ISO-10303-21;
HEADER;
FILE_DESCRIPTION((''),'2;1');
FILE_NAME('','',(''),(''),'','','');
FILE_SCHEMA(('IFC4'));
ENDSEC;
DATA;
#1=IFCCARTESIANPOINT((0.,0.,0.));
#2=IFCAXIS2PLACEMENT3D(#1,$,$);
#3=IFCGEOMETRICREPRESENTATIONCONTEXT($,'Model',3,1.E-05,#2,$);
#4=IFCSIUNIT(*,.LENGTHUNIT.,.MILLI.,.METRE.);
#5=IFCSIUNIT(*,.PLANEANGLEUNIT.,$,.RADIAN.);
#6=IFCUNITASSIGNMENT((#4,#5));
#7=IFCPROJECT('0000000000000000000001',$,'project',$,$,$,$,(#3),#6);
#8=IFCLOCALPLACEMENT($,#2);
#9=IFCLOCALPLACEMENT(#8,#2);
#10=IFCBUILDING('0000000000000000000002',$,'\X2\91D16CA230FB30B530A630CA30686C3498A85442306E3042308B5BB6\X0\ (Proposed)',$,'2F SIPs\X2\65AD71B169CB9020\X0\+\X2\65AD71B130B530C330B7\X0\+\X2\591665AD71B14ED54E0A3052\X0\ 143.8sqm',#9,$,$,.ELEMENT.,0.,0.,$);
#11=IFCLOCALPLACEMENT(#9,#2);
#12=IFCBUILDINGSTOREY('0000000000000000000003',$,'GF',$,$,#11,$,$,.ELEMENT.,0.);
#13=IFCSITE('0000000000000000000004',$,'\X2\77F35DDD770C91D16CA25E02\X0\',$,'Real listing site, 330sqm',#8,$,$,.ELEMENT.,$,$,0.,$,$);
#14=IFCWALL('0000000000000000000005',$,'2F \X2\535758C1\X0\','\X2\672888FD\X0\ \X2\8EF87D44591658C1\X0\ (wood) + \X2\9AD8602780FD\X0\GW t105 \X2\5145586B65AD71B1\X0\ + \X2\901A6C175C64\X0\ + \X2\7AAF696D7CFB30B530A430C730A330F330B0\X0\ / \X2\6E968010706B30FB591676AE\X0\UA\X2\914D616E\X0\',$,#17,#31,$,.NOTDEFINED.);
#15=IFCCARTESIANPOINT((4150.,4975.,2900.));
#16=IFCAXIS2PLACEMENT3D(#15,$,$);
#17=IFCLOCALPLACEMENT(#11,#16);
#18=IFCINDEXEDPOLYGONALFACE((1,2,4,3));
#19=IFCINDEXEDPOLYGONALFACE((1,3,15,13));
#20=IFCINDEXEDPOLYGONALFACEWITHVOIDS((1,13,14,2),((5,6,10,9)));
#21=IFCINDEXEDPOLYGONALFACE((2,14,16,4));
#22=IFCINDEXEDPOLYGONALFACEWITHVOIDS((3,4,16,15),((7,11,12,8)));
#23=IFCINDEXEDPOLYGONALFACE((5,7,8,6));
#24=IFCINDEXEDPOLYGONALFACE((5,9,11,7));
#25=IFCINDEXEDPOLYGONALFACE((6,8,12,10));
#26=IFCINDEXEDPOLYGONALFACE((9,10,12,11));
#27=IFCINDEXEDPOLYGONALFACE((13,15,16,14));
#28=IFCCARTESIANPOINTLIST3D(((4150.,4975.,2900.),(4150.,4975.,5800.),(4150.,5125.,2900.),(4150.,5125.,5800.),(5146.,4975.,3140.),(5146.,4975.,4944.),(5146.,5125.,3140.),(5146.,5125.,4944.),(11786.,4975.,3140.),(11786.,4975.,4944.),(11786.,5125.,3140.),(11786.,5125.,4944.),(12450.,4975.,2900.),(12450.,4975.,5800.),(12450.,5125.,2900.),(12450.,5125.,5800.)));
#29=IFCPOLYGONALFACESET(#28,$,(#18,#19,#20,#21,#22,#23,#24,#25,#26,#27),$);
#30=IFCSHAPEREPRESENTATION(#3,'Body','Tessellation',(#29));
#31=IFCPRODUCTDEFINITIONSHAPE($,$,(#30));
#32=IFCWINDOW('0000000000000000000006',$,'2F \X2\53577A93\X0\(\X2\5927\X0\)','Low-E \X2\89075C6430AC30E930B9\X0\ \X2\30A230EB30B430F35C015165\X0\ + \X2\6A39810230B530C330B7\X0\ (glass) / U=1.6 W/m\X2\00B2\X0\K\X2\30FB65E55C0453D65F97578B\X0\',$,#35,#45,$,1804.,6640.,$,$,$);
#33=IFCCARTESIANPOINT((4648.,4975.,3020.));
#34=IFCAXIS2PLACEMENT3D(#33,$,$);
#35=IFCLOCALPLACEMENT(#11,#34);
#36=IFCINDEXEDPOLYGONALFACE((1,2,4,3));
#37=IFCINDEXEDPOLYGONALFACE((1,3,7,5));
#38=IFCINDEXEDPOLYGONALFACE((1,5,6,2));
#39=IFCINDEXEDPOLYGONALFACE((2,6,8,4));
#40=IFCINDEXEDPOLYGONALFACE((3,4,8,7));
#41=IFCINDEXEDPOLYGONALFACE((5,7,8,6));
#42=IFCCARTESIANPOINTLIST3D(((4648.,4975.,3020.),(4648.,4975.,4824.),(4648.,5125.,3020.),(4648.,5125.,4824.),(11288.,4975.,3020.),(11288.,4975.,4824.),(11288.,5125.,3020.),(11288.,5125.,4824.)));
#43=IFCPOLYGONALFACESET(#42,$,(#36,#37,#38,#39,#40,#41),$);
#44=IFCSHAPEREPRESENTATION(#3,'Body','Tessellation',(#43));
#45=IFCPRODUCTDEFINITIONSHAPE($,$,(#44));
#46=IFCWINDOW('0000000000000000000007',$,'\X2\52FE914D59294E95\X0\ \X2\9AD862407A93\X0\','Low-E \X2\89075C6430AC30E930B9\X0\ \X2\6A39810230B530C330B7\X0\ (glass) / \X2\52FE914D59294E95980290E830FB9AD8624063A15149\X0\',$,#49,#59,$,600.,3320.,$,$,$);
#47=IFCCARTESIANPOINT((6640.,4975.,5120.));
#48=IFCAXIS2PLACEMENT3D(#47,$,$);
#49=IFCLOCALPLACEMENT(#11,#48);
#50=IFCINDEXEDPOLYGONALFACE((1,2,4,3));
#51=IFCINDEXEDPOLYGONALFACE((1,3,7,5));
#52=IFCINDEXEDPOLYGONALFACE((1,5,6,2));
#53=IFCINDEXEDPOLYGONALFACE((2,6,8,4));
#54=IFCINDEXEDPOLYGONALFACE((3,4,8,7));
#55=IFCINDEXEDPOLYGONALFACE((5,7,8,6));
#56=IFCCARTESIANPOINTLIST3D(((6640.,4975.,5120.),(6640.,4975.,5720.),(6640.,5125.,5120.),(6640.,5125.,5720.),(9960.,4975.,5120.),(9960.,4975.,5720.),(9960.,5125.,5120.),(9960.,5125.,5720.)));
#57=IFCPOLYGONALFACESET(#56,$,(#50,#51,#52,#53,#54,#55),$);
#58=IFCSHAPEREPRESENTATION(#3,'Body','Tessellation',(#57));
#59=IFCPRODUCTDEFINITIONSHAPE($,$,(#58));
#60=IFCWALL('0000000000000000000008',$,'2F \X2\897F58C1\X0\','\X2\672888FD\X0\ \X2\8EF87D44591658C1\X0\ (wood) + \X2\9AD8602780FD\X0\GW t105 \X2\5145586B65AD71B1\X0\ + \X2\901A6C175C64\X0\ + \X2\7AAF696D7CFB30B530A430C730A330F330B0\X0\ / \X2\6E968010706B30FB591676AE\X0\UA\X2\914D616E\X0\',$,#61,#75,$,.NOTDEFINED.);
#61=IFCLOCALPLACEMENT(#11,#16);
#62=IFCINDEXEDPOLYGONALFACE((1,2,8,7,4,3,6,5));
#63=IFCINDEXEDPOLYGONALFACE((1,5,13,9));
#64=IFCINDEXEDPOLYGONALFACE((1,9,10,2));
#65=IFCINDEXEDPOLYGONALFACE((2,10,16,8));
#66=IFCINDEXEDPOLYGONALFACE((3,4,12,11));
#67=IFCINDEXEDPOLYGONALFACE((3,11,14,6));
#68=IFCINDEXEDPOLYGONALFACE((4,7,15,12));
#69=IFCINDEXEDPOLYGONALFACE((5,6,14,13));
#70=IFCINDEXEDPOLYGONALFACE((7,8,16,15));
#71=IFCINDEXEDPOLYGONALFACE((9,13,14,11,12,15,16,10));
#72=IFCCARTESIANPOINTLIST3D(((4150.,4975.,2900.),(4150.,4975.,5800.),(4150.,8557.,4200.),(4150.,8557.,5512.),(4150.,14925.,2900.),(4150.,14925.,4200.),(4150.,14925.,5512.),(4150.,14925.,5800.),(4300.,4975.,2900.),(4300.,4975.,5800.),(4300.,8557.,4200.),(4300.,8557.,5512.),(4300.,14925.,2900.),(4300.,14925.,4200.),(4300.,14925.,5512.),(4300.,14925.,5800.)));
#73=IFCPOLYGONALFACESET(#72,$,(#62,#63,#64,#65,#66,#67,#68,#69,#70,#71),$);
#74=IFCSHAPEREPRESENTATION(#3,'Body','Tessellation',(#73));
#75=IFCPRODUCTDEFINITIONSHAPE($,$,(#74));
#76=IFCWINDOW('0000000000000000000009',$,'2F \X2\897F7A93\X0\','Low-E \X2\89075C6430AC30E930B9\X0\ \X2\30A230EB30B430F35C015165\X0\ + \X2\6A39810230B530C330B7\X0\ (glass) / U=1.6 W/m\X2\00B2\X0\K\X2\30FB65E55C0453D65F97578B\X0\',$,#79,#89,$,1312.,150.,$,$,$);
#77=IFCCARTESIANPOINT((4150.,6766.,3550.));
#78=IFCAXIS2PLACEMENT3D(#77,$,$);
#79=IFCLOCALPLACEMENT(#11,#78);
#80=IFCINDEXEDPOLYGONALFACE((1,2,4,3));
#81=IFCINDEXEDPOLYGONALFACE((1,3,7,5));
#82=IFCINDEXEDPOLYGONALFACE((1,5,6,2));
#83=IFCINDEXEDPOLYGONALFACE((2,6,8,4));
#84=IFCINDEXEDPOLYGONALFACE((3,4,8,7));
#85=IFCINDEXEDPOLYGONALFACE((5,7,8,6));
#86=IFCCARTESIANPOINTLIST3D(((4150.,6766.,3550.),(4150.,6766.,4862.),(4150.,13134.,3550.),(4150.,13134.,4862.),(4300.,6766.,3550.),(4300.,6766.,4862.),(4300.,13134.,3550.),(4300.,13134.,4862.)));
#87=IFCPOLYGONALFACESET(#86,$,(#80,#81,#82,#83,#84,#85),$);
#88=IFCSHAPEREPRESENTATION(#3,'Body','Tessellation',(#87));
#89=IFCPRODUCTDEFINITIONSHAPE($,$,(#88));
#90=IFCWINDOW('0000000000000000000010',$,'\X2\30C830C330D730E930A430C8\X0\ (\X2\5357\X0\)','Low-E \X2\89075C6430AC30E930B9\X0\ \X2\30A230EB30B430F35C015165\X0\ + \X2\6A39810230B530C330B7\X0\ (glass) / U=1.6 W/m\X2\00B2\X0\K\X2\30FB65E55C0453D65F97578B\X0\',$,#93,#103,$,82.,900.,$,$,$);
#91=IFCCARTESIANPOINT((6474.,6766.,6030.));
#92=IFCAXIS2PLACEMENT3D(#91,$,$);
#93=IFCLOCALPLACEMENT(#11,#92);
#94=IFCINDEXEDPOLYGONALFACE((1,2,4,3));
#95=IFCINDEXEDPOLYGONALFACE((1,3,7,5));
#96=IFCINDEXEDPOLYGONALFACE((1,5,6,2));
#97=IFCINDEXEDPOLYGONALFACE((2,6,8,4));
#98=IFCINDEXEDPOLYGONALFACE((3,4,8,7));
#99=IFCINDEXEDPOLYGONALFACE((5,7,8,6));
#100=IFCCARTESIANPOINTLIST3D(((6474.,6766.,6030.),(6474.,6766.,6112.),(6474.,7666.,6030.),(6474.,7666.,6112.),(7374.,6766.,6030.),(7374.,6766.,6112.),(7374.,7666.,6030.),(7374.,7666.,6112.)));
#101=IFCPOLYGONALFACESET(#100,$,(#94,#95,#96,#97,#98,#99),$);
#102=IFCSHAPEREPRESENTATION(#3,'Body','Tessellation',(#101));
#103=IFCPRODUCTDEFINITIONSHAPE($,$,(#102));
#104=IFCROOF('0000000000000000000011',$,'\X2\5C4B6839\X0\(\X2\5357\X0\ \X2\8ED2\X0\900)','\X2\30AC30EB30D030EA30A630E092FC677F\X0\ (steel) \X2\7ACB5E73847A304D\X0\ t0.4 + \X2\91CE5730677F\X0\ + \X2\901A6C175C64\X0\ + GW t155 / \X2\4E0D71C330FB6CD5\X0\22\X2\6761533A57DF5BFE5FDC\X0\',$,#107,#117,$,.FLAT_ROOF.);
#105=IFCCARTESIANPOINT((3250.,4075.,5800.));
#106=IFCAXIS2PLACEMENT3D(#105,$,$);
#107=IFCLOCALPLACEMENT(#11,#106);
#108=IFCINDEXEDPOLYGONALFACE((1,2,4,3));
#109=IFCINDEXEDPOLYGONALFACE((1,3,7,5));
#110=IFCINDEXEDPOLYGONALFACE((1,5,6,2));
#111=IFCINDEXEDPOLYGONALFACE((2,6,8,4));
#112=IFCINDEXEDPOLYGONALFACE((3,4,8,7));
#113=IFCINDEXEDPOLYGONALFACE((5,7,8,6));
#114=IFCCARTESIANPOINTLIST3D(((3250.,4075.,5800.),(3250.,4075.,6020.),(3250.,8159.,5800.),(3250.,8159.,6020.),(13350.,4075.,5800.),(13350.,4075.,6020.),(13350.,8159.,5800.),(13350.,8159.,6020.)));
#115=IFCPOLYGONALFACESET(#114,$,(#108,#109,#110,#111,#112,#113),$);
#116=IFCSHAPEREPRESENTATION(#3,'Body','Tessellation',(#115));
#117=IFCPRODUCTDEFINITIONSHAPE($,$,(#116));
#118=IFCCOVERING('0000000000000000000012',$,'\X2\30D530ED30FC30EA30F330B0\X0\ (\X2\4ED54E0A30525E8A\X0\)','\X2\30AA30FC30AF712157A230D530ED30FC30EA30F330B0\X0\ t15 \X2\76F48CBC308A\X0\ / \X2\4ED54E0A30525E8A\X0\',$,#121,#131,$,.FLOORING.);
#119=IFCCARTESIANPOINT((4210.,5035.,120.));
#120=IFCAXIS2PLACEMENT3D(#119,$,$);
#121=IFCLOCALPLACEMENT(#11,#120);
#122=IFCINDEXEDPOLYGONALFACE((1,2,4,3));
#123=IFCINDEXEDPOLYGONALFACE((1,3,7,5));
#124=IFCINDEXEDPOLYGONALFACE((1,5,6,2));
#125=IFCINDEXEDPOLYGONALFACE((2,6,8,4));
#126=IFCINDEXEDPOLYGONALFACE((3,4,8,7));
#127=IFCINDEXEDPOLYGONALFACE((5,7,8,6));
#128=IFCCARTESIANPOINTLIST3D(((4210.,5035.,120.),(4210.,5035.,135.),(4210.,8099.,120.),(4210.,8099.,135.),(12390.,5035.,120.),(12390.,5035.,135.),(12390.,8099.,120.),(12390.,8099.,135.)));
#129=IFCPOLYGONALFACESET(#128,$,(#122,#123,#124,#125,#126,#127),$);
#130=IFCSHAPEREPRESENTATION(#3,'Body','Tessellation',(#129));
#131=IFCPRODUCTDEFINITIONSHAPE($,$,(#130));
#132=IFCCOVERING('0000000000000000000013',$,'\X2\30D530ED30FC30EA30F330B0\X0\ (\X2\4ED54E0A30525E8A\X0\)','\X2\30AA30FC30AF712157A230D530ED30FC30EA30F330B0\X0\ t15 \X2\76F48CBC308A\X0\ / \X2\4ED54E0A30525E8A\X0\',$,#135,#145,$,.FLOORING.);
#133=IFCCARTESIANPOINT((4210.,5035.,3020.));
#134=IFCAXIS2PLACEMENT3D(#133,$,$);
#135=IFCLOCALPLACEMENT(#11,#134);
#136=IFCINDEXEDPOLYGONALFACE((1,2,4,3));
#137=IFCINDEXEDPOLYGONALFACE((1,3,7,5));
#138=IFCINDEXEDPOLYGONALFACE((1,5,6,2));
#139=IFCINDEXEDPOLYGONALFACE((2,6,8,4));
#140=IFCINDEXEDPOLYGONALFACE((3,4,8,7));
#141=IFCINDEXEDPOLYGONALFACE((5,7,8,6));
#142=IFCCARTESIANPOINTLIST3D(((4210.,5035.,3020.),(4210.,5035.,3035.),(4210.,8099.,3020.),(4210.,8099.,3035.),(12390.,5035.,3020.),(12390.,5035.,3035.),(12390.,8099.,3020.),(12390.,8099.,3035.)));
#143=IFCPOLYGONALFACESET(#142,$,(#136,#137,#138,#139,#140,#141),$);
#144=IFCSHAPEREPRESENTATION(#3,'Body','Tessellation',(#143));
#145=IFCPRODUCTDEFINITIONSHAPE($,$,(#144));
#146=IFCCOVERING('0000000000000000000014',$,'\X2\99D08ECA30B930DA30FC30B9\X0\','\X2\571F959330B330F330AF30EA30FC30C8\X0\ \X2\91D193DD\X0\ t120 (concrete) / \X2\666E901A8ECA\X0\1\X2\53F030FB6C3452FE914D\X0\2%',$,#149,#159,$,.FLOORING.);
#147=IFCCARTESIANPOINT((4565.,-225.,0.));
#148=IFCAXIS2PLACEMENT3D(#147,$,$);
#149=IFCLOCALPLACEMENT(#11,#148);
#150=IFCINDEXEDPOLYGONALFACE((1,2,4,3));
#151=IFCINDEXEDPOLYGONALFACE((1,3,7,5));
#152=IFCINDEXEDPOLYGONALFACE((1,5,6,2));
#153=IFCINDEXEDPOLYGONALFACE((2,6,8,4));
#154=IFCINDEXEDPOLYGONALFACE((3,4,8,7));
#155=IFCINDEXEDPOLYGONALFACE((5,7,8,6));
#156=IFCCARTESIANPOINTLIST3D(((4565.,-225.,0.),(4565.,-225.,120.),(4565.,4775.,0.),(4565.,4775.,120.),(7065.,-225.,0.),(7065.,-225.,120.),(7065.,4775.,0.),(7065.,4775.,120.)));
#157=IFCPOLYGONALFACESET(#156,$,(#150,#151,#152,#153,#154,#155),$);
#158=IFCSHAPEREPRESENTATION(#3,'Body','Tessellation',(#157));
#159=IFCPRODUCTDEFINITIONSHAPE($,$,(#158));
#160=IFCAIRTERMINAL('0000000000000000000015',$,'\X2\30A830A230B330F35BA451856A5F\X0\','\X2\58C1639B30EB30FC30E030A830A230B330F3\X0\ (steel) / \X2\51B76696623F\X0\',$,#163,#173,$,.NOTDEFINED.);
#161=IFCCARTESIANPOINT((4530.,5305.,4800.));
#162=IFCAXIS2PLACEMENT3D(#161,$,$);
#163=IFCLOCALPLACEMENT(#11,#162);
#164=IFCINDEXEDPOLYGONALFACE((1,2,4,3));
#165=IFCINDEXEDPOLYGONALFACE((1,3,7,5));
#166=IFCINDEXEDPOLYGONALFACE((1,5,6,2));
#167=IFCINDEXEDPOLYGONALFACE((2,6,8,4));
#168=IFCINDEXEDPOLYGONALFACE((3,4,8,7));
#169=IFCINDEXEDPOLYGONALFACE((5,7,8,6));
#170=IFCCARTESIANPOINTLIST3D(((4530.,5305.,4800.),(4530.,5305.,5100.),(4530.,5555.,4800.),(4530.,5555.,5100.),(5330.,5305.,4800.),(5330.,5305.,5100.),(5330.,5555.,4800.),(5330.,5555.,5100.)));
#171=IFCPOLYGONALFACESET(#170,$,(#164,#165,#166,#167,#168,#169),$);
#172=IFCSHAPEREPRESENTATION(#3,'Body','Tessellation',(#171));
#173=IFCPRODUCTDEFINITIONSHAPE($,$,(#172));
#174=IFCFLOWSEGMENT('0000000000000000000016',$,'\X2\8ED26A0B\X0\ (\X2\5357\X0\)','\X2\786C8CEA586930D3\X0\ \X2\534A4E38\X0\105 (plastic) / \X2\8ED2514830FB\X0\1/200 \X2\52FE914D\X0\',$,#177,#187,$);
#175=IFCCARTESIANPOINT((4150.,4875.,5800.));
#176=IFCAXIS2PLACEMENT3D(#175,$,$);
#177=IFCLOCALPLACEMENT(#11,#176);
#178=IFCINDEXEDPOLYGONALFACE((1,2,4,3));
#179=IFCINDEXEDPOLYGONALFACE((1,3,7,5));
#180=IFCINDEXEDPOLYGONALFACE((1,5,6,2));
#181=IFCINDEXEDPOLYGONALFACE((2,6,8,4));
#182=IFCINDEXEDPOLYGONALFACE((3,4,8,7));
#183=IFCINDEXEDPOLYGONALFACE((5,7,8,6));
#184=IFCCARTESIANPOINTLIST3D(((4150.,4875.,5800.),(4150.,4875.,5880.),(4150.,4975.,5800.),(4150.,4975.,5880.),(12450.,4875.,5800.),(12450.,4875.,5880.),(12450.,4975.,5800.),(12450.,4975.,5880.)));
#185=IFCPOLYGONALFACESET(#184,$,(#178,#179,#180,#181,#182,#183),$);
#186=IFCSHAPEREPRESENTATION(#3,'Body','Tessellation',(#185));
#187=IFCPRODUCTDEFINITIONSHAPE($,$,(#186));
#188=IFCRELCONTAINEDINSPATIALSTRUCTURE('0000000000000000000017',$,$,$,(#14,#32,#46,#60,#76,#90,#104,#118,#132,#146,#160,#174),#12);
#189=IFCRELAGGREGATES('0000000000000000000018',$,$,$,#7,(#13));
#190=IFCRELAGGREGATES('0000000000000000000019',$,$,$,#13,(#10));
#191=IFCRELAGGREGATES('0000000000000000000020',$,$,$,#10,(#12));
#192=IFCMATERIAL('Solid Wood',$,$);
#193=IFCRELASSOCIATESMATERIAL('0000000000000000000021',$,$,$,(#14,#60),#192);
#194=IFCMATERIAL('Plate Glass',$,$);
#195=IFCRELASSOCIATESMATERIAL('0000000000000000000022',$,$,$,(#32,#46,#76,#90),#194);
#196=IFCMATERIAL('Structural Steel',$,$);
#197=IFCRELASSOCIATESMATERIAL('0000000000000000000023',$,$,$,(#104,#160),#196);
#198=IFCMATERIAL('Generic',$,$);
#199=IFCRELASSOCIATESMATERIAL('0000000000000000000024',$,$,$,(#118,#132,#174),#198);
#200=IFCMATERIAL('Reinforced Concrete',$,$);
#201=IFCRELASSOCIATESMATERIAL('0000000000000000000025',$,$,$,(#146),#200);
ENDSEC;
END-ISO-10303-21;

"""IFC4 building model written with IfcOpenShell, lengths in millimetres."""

from ifc_helpers import new_model, si_unit, frame, frame_2d, origin, place, context, project, spatial, rectangle, extrude, material, element, fill, save


model = new_model("IFC4")

# Units and contexts
model_context = context("Model", 3, precision=1e-05, world=origin())
ifc_project = project(units=[si_unit("LENGTHUNIT", "METRE", prefix="MILLI"), si_unit("PLANEANGLEUNIT", "RADIAN")], contexts=[model_context])

# Site, building, storey
site_placement = place(None, origin())
site = spatial("IfcSite", under=ifc_project, at=site_placement, Name="石川県金沢市", ObjectType="Real listing site, 330sqm", CompositionType="ELEMENT", RefElevation=0.0)
building_placement = place(site_placement, origin())
building = spatial("IfcBuilding", under=site, at=building_placement, Name="金沢・サウナと水風呂のある家 (Proposed)", ObjectType="2F SIPs断熱構造+断熱サッシ+外断熱仕上げ 143.8sqm", CompositionType="ELEMENT", ElevationOfRefHeight=0.0, ElevationOfTerrain=0.0)
storey_placement = place(building_placement, origin())
storey = spatial("IfcBuildingStorey", under=building, at=storey_placement, Name="GF", CompositionType="ELEMENT", Elevation=0.0)

# Shared definitions
ifc_material_1 = material(Name="Solid Wood")

# Shared definitions
ifc_material_2 = material(Name="Reinforced Concrete")

# Shared definitions
ifc_material_3 = material(Name="Plate Glass")

# Wall, openings, windows
wall_1_placement = place(storey_placement, frame((4150.0, 4975.0, 2900.0)))
wall_1 = element("IfcWall", 1, at=wall_1_placement, inside=storey, material=ifc_material_1, Name="2F 南壁", Description="木製 軸組外壁 (wood) + 高性能GW t105 充填断熱 + 通気層 + 窯業系サイディング / 準耐火・外皮UA配慮", PredefinedType="NOTDEFINED", context=model_context, shape_type="SweptSolid", body=[
    extrude(rectangle(XDim=8300.0, YDim=150.0, at=frame_2d((4150.0, 75.0))), frame((4150.0, 4975.0, 2900.0)), (0.0, 0.0, 1.0), 2900.0),
])
opening_1_placement = place(storey_placement, frame((4648.0, 4975.0, 3020.0)))
opening_1 = element("IfcOpeningElement", 2, at=opening_1_placement, cuts=wall_1, PredefinedType="NOTDEFINED", context=model_context, shape_type="SweptSolid", body=[
    extrude(rectangle(XDim=6640.0, YDim=150.0, at=frame_2d((3320.0, 75.0))), frame((4648.0, 4975.0, 3020.0)), (0.0, 0.0, 1.0), 1804.0),
])
opening_2_placement = place(storey_placement, frame((6640.0, 4975.0, 5120.0)))
opening_2 = element("IfcOpeningElement", 3, at=opening_2_placement, cuts=wall_1, PredefinedType="NOTDEFINED", context=model_context, shape_type="SweptSolid", body=[
    extrude(rectangle(XDim=3320.0, YDim=150.0, at=frame_2d((1660.0, 75.0))), frame((6640.0, 4975.0, 5120.0)), (0.0, 0.0, 1.0), 600.0),
])
window_1_placement = place(storey_placement, frame((4648.0, 4975.0, 3020.0)))
window_1 = element("IfcWindow", 4, at=window_1_placement, inside=storey, material=ifc_material_3, Name="2F 南窓(大)", Description="Low-E 複層ガラス アルゴン封入 + 樹脂サッシ (glass) / U=1.6 W/m²K・日射取得型", OverallHeight=1804.0, OverallWidth=6640.0, context=model_context, shape_type="SweptSolid", body=[
    extrude(rectangle(XDim=6640.0, YDim=150.0, at=frame_2d((3320.0, 75.0))), frame((4648.0, 4975.0, 3020.0)), (0.0, 0.0, 1.0), 1804.0),
])
fill(opening_1, window_1)
window_2_placement = place(storey_placement, frame((6640.0, 4975.0, 5120.0)))
window_2 = element("IfcWindow", 5, at=window_2_placement, inside=storey, material=ifc_material_3, Name="勾配天井 高所窓", Description="Low-E 複層ガラス 樹脂サッシ (glass) / 勾配天井頂部・高所採光", OverallHeight=600.0, OverallWidth=3320.0, context=model_context, shape_type="SweptSolid", body=[
    extrude(rectangle(XDim=3320.0, YDim=150.0, at=frame_2d((1660.0, 75.0))), frame((6640.0, 4975.0, 5120.0)), (0.0, 0.0, 1.0), 600.0),
])
fill(opening_2, window_2)

# Wall, opening, window
wall_2_placement = place(storey_placement, frame((4150.0, 4975.0, 2900.0)))
wall_2 = element("IfcWall", 6, at=wall_2_placement, inside=storey, material=ifc_material_1, Name="2F 西壁", Description="木製 軸組外壁 (wood) + 高性能GW t105 充填断熱 + 通気層 + 窯業系サイディング / 準耐火・外皮UA配慮", PredefinedType="NOTDEFINED", context=model_context, shape_type="SweptSolid", body=[
    extrude(rectangle(XDim=150.0, YDim=9950.0, at=frame_2d((75.0, 4975.0))), frame((4150.0, 4975.0, 2900.0)), (0.0, 0.0, 1.0), 2900.0),
])
opening_3_placement = place(storey_placement, frame((4150.0, 6766.0, 3550.0)))
opening_3 = element("IfcOpeningElement", 7, at=opening_3_placement, cuts=wall_2, PredefinedType="NOTDEFINED", context=model_context, shape_type="SweptSolid", body=[
    extrude(rectangle(XDim=150.0, YDim=6368.0, at=frame_2d((75.0, 3184.0))), frame((4150.0, 6766.0, 3550.0)), (0.0, 0.0, 1.0), 1312.0),
])
window_3_placement = place(storey_placement, frame((4150.0, 6766.0, 3550.0)))
window_3 = element("IfcWindow", 8, at=window_3_placement, inside=storey, material=ifc_material_3, Name="2F 西窓", Description="Low-E 複層ガラス アルゴン封入 + 樹脂サッシ (glass) / U=1.6 W/m²K・日射取得型", OverallHeight=1312.0, OverallWidth=150.0, context=model_context, shape_type="SweptSolid", body=[
    extrude(rectangle(XDim=150.0, YDim=6368.0, at=frame_2d((75.0, 3184.0))), frame((4150.0, 6766.0, 3550.0)), (0.0, 0.0, 1.0), 1312.0),
])
fill(opening_3, window_3)

# Window
window_4_placement = place(storey_placement, frame((6474.0, 6766.0, 6030.0)))
element("IfcWindow", 9, at=window_4_placement, inside=storey, material=ifc_material_3, Name="トップライト (南)", Description="Low-E 複層ガラス アルゴン封入 + 樹脂サッシ (glass) / U=1.6 W/m²K・日射取得型", OverallHeight=82.0, OverallWidth=900.0, context=model_context, shape_type="SweptSolid", body=[
    extrude(rectangle(XDim=900.0, YDim=900.0, at=frame_2d((450.0, 450.0))), frame((6474.0, 6766.0, 6030.0)), (0.0, 0.0, 1.0), 82.0),
])

# Roof
ifc_material_4 = material(Name="Structural Steel")
for number, where, name in (
    (10, (3250.0, 4075.0, 5800.0), "屋根(南 軒900)"),
):
    element("IfcRoof", number, at=place(storey_placement, frame(where)), inside=storey, material=ifc_material_4, Name=name, Description="ガルバリウム鋼板 (steel) 立平葺き t0.4 + 野地板 + 通気層 + GW t155 / 不燃・法22条区域対応", PredefinedType="FLAT_ROOF", context=model_context, shape_type="SweptSolid", body=[
        extrude(rectangle(XDim=10100.0, YDim=4084.0, at=frame_2d((5050.0, 2042.0))), frame((3250.0, 4075.0, 5800.0)), (0.0, 0.0, 1.0), 220.0),
    ])

# Coverings
ifc_material_5 = material(Name="Generic")
covering_1_placement = place(storey_placement, frame((4210.0, 5035.0, 120.0)))
element("IfcCovering", 11, at=covering_1_placement, inside=storey, material=ifc_material_5, Name="フローリング (仕上げ床)", Description="オーク無垢フローリング t15 直貼り / 仕上げ床", PredefinedType="FLOORING", context=model_context, shape_type="SweptSolid", body=[
    extrude(rectangle(XDim=8180.0, YDim=3064.0, at=frame_2d((4090.0, 1532.0))), frame((4210.0, 5035.0, 120.0)), (0.0, 0.0, 1.0), 15.0),
])
covering_2_placement = place(storey_placement, frame((4210.0, 5035.0, 3020.0)))
element("IfcCovering", 12, at=covering_2_placement, inside=storey, material=ifc_material_5, Name="フローリング (仕上げ床)", Description="オーク無垢フローリング t15 直貼り / 仕上げ床", PredefinedType="FLOORING", context=model_context, shape_type="SweptSolid", body=[
    extrude(rectangle(XDim=8180.0, YDim=3064.0, at=frame_2d((4090.0, 1532.0))), frame((4210.0, 5035.0, 3020.0)), (0.0, 0.0, 1.0), 15.0),
])
covering_3_placement = place(storey_placement, frame((4565.0, -225.0, 0.0)))
element("IfcCovering", 13, at=covering_3_placement, inside=storey, material=ifc_material_2, Name="駐車スペース", Description="土間コンクリート 金鏝 t120 (concrete) / 普通車1台・水勾配2%", PredefinedType="FLOORING", context=model_context, shape_type="SweptSolid", body=[
    extrude(rectangle(XDim=2500.0, YDim=5000.0, at=frame_2d((1250.0, 2500.0))), frame((4565.0, -225.0, 0.0)), (0.0, 0.0, 1.0), 120.0),
])

# Air terminal
air_terminal_placement = place(storey_placement, frame((4530.0, 5305.0, 4800.0)))
element("IfcAirTerminal", 14, at=air_terminal_placement, inside=storey, material=ifc_material_4, Name="エアコン室内機", Description="壁掛ルームエアコン (steel) / 冷暖房", PredefinedType="NOTDEFINED", context=model_context, shape_type="SweptSolid", body=[
    extrude(rectangle(XDim=800.0, YDim=250.0, at=frame_2d((400.0, 125.0))), frame((4530.0, 5305.0, 4800.0)), (0.0, 0.0, 1.0), 300.0),
])

# Flow segment
flow_segment_1_placement = place(storey_placement, frame((4150.0, 4875.0, 5800.0)))
element("IfcFlowSegment", 15, at=flow_segment_1_placement, inside=storey, material=ifc_material_5, Name="軒樋 (南)", Description="硬質塩ビ 半丸105 (plastic) / 軒先・1/200 勾配", context=model_context, shape_type="SweptSolid", body=[
    extrude(rectangle(XDim=8300.0, YDim=100.0, at=frame_2d((4150.0, 50.0))), frame((4150.0, 4875.0, 5800.0)), (0.0, 0.0, 1.0), 80.0),
])

save(model, "model.ifc")
